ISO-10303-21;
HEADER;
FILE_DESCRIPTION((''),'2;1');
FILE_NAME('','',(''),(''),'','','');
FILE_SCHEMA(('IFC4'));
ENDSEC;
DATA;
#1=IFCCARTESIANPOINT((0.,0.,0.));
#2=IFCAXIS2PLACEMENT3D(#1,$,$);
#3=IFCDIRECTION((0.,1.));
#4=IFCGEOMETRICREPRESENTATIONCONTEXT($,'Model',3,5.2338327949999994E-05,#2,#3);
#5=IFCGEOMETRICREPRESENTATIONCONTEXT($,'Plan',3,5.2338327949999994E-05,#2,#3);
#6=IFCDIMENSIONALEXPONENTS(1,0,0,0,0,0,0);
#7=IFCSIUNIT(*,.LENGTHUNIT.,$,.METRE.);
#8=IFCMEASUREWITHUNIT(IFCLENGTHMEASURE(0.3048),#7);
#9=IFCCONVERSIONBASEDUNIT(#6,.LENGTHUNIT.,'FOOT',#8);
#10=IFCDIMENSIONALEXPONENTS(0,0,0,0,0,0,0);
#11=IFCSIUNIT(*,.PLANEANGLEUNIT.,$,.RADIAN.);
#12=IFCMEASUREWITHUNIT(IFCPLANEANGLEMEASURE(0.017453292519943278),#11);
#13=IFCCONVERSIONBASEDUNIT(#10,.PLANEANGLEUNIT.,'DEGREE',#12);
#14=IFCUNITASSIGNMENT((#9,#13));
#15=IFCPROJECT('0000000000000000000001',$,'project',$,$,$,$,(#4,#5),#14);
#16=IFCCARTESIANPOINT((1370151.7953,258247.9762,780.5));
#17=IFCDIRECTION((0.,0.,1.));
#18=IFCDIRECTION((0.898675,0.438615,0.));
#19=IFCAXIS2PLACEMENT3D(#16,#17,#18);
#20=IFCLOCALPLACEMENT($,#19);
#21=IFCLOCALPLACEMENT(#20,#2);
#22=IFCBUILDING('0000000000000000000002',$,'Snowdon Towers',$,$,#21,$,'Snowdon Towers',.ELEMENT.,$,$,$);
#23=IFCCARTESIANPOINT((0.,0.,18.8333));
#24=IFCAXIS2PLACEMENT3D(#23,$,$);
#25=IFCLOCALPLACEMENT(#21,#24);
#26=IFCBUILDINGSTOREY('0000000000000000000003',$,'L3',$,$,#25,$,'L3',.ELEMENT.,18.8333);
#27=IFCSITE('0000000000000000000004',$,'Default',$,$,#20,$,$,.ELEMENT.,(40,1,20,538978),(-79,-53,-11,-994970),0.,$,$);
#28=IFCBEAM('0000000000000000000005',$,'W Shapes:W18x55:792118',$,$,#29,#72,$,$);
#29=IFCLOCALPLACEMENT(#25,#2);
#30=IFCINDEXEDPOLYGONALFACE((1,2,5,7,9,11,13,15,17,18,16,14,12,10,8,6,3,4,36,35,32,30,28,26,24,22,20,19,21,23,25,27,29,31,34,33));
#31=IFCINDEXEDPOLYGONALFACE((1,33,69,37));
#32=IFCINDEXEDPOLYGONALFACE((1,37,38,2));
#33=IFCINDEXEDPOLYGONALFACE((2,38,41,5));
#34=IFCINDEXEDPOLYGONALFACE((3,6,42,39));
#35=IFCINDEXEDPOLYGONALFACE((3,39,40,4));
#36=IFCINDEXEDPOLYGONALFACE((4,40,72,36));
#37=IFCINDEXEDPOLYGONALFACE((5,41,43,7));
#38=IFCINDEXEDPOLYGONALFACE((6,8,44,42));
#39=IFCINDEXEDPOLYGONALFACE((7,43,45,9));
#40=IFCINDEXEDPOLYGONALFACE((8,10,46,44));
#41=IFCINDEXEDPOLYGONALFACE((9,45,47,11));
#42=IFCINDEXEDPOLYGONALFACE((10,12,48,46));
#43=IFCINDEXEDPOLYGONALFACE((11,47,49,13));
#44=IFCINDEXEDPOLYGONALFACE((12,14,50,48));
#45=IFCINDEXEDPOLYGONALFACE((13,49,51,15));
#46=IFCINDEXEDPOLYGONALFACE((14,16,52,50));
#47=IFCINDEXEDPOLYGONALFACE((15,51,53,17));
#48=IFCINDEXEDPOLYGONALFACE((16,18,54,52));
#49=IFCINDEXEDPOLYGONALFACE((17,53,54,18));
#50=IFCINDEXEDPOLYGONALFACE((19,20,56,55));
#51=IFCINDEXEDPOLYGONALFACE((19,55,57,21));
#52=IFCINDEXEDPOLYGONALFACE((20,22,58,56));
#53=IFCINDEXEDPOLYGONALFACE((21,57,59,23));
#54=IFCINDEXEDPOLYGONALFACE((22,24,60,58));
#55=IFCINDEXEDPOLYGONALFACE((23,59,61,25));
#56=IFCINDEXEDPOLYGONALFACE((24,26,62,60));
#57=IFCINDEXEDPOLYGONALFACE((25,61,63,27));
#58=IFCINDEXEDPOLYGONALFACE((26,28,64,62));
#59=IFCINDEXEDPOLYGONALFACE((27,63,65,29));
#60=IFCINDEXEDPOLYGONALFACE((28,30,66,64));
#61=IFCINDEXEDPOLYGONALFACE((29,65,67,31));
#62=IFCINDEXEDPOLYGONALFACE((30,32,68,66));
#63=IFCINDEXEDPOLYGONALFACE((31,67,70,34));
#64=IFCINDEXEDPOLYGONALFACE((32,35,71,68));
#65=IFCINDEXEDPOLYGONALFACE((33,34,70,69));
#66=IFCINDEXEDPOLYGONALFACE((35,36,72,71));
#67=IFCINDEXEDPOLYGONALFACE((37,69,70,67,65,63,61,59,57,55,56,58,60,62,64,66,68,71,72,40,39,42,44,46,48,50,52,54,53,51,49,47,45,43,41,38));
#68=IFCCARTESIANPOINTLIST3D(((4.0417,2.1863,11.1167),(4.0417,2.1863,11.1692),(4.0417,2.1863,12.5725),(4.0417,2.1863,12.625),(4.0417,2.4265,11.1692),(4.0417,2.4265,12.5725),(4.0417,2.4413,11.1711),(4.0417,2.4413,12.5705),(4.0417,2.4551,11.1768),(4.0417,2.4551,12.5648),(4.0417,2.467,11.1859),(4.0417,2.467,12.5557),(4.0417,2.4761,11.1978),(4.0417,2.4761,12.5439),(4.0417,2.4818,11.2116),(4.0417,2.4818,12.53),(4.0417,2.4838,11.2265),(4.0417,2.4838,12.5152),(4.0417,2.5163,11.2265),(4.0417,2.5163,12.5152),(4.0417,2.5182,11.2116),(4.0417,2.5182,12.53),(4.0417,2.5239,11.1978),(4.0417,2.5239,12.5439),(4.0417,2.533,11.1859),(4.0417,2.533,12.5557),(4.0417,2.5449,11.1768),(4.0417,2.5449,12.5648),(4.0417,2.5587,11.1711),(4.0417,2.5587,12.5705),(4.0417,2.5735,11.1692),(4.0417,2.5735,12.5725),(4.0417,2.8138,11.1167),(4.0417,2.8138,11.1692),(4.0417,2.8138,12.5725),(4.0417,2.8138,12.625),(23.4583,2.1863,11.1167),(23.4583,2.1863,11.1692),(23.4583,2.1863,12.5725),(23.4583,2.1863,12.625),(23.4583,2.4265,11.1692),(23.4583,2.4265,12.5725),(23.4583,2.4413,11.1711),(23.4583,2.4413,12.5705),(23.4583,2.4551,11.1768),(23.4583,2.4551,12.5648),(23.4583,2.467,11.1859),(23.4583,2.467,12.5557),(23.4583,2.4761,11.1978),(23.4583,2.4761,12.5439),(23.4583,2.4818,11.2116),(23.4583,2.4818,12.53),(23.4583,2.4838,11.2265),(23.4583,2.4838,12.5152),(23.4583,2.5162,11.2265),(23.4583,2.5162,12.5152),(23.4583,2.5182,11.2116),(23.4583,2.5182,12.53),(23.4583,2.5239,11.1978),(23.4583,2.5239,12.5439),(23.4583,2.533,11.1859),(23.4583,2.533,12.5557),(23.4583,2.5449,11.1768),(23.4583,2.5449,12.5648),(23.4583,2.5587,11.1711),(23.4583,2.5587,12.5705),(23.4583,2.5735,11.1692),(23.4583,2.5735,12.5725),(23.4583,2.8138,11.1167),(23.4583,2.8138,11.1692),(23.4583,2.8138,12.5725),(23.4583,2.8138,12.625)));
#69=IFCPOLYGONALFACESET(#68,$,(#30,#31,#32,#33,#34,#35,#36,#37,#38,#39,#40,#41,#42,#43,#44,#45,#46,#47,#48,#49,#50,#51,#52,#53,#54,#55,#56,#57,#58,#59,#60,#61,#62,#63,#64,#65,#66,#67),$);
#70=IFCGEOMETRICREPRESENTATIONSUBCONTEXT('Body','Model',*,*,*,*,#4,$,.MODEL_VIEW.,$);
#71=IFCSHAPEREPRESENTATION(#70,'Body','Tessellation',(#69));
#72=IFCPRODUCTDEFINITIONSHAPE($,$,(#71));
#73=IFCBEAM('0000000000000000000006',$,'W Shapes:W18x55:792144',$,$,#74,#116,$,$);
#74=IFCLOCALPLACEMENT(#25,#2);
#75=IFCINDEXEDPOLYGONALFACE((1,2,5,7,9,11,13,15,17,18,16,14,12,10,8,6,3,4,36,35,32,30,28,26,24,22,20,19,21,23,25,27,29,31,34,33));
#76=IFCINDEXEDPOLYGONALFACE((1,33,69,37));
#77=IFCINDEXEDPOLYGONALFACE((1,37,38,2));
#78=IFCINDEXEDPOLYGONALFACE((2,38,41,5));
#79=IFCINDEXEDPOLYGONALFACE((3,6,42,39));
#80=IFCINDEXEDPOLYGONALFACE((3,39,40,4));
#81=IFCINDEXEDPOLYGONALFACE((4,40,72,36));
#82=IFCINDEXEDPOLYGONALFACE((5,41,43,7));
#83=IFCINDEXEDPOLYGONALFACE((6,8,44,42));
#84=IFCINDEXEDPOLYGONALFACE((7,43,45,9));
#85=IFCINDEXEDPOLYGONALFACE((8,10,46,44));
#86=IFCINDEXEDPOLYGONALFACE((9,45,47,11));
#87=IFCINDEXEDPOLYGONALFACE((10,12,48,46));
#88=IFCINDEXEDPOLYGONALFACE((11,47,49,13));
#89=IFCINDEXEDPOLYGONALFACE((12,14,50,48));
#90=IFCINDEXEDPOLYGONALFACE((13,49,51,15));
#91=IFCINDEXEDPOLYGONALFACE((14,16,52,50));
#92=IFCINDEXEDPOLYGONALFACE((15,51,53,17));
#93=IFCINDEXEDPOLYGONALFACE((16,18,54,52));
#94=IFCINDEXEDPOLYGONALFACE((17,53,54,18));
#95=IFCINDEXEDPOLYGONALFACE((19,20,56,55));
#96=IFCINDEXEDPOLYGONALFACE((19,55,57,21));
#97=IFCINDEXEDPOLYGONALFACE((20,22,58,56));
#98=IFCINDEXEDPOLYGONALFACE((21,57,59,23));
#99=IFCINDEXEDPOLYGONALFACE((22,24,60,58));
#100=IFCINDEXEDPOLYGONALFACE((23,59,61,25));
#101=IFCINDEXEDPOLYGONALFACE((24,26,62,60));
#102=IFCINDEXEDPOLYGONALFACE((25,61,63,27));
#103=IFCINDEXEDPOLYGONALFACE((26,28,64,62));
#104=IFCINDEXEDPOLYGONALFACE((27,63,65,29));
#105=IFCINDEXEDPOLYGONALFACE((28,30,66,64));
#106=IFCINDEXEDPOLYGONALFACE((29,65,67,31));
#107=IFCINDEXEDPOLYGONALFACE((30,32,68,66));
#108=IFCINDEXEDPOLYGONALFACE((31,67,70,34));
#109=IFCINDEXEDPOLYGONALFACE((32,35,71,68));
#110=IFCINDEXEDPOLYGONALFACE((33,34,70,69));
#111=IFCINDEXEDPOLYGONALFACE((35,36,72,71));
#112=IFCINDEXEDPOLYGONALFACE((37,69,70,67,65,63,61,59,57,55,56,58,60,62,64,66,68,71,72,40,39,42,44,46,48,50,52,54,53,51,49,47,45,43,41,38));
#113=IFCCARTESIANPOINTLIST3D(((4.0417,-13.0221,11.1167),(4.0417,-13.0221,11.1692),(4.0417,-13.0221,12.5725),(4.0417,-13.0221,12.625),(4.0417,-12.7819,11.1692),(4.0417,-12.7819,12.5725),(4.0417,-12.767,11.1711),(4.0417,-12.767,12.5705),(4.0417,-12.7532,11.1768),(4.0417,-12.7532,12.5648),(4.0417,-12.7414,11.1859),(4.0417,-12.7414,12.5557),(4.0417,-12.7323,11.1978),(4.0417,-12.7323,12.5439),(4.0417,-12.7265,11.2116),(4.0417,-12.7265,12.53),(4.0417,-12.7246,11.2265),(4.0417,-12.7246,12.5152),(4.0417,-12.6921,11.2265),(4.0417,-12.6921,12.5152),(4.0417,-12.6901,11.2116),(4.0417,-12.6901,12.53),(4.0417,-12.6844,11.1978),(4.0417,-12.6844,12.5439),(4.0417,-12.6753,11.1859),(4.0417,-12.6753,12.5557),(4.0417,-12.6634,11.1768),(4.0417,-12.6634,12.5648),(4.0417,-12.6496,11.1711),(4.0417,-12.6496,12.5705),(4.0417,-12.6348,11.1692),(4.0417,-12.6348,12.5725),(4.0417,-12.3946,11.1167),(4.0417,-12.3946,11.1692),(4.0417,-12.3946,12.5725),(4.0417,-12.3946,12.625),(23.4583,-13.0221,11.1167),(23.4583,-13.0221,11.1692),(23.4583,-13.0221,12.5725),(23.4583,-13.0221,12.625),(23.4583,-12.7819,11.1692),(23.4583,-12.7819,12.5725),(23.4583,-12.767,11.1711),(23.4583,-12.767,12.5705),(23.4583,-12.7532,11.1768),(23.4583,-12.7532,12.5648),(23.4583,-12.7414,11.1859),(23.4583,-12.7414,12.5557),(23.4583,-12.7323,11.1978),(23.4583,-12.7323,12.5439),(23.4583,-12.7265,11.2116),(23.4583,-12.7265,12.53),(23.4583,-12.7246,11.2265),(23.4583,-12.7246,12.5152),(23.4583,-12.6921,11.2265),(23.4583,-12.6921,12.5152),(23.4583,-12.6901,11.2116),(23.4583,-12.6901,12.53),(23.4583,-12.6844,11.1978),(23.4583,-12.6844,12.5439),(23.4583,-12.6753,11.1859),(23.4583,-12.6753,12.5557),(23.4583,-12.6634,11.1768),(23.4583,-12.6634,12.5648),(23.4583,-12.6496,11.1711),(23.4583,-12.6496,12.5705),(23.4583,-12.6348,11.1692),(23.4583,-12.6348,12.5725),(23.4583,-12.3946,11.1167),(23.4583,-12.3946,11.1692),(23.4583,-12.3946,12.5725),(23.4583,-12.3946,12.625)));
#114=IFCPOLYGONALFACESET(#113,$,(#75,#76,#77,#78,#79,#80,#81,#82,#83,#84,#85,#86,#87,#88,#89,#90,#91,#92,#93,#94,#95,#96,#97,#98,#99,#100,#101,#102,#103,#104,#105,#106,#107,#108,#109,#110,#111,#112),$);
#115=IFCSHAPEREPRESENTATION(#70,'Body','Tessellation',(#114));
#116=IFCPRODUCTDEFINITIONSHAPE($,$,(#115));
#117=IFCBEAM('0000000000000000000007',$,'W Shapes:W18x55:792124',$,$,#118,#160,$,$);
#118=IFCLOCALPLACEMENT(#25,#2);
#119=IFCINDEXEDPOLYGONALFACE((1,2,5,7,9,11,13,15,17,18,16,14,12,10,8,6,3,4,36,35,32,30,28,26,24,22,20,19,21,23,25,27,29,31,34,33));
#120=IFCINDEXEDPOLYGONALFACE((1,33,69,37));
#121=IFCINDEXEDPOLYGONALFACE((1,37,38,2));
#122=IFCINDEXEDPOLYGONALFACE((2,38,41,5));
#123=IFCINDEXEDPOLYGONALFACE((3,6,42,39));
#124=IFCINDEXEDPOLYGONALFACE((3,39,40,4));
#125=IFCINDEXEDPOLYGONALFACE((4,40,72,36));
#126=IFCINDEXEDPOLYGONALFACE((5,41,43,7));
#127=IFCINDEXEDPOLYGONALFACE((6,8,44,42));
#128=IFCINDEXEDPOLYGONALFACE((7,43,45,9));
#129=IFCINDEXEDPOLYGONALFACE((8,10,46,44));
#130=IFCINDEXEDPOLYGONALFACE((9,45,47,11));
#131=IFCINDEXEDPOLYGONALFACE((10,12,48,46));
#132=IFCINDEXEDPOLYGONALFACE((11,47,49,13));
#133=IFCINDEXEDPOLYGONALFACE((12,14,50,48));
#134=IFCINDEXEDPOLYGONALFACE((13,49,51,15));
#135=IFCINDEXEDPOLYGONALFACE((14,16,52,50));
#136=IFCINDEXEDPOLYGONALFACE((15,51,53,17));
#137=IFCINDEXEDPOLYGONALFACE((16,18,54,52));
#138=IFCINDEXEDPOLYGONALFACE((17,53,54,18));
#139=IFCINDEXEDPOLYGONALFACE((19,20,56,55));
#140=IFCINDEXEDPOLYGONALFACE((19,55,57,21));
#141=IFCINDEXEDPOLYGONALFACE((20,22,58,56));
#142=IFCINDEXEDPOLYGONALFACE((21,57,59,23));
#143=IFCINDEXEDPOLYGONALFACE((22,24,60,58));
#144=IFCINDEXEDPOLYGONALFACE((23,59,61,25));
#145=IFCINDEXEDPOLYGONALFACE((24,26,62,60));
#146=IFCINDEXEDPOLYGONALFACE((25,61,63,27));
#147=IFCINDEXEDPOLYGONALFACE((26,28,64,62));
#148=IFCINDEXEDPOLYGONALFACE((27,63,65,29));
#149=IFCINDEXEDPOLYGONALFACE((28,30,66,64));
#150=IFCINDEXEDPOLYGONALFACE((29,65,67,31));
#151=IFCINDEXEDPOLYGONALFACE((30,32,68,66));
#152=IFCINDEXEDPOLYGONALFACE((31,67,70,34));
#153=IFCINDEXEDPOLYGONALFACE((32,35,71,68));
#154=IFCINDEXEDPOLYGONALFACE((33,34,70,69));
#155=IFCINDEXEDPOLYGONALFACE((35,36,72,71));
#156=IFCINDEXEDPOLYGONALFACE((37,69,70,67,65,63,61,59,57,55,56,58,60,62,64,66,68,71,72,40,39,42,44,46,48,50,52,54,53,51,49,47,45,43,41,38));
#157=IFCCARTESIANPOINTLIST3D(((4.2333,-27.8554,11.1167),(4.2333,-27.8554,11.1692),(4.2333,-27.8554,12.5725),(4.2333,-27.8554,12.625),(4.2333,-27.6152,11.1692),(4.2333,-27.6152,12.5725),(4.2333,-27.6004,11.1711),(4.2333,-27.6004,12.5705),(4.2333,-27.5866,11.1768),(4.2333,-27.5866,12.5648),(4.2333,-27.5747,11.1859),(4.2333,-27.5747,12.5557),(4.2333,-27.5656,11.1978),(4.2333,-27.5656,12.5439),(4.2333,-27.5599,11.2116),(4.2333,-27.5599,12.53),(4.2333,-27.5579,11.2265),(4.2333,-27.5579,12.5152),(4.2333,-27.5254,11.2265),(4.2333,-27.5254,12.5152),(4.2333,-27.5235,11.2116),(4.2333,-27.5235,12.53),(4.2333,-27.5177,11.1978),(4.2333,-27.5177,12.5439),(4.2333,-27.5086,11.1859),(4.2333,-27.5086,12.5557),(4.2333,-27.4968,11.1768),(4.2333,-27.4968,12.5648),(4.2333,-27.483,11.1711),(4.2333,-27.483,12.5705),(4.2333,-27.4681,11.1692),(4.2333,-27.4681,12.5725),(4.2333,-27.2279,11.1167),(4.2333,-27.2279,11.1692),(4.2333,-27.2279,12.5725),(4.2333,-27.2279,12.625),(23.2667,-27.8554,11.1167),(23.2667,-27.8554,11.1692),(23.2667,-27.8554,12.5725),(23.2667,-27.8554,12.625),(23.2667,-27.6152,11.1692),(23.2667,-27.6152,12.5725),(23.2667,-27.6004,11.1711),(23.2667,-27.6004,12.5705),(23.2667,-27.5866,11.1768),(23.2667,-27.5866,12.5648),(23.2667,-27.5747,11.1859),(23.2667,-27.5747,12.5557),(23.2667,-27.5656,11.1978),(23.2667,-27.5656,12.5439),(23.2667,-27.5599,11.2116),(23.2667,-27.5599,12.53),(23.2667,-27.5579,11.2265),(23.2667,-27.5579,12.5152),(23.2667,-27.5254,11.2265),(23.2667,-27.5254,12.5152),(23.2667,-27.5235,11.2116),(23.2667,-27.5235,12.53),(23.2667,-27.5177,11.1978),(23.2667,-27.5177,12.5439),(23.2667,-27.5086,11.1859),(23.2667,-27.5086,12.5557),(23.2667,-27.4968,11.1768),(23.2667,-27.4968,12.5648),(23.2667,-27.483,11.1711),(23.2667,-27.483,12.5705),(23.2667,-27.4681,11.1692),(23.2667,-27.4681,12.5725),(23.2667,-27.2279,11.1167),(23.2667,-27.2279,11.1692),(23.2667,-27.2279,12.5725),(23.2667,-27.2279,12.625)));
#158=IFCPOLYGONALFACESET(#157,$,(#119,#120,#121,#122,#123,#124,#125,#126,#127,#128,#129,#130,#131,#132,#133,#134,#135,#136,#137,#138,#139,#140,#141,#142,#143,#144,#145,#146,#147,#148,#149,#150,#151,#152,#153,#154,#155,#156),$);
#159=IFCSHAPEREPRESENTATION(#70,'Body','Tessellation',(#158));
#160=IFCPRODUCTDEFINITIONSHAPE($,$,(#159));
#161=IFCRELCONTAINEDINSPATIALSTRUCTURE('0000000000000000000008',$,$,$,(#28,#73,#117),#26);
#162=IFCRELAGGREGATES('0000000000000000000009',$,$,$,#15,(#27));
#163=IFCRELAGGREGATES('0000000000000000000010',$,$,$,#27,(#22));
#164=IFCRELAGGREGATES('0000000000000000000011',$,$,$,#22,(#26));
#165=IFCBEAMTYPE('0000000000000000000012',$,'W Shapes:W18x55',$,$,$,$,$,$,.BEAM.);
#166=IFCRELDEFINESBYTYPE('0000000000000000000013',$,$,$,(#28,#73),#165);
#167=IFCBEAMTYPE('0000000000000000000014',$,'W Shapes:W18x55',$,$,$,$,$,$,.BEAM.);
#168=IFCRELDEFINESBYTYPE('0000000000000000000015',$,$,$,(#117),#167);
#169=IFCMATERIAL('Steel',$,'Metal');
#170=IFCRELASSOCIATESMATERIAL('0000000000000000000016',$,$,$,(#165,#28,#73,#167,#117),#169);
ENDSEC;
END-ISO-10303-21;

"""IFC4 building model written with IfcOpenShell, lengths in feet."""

from ifc_helpers import new_model, entity, si_unit, converted_unit, direction, frame, origin, place, context, subcontext, project, spatial, line, arc, indexed_curve, outline, extrude, source, transform, mapped, material, type_object, type_shapes, element, save


model = new_model("IFC4")

# Units and contexts
model_context = context("Model", 3, precision=5.2338327949999994e-05, world=origin(), true_north=direction((0.0, 1.0)))
plan_context = context("Plan", 3, precision=5.2338327949999994e-05, world=origin(), true_north=direction((0.0, 1.0)))
body_context = subcontext(model_context, "Body", "Model", "MODEL_VIEW")
ifc_project = project(units=[converted_unit("LENGTHUNIT", "FOOT", entity("IfcLengthMeasure", 0.3048), si_unit("LENGTHUNIT", "METRE"), dimensions=[1, 0, 0, 0, 0, 0, 0]), converted_unit("PLANEANGLEUNIT", "DEGREE", entity("IfcPlaneAngleMeasure", 0.017453292519943278), si_unit("PLANEANGLEUNIT", "RADIAN"), dimensions=[0, 0, 0, 0, 0, 0, 0])], contexts=[model_context, plan_context])

# Site, building, storey
site_placement = place(None, frame((1370151.7953, 258247.9762, 780.5), z_axis=(0.0, 0.0, 1.0), x_axis=(0.898675, 0.438615, 0.0)))
site = spatial("IfcSite", under=ifc_project, at=site_placement, Name="Default", CompositionType="ELEMENT", RefLatitude=(40, 1, 20, 538978), RefLongitude=(-79, -53, -11, -994970), RefElevation=0.0)
building_placement = place(site_placement, origin())
building = spatial("IfcBuilding", under=site, at=building_placement, Name="Snowdon Towers", LongName="Snowdon Towers", CompositionType="ELEMENT")
storey_placement = place(building_placement, frame((0.0, 0.0, 18.8333)))
storey = spatial("IfcBuildingStorey", under=building, at=storey_placement, Name="L3", LongName="L3", CompositionType="ELEMENT", Elevation=18.8333)

# Beams
ifc_material_1 = material(Name="Steel", Category="Metal")
beam_type_1 = type_object("IfcBeamType", Name="W Shapes:W18x55", PredefinedType="BEAM", material=ifc_material_1)
shared_shape_1 = source(origin(), body_context, "Body", "SweptSolid", [
    extrude(outline(indexed_curve([(-0.7542, -0.3138), (-0.7017, -0.3138), (-0.7017, -0.0735), (-0.6849, -0.033), (-0.6444, -0.0162), (0.6444, -0.0162), (0.6849, -0.033), (0.7017, -0.0735), (0.7017, -0.3138), (0.7542, -0.3138), (0.7542, 0.3138), (0.7017, 0.3138), (0.7017, 0.0735), (0.6849, 0.033), (0.6444, 0.0163), (-0.6444, 0.0163), (-0.6849, 0.033), (-0.7017, 0.0735), (-0.7017, 0.3137), (-0.7542, 0.3137)], segments=[line(1, 2, 3), arc(3, 4, 5), line(5, 6), arc(6, 7, 8), line(8, 9, 10, 11, 12, 13), arc(13, 14, 15), line(15, 16), arc(16, 17, 18), line(18, 19, 20, 1)], self_intersect=False)), frame((-9.7917, 0.0, 0.0), z_axis=(1.0, 0.0, 0.0), x_axis=(0.0, 0.0, -1.0)), (0.0, 0.0, 1.0), 19.4167),
])
type_shapes(beam_type_1, [shared_shape_1])
for number, where, name in (
    (1, (13.8333, 2.5, 11.8708), "W Shapes:W18x55:792118"),
    (2, (13.8333, -12.7083, 11.8708), "W Shapes:W18x55:792144"),
):
    element("IfcBeam", number, at=place(storey_placement, frame(where)), inside=storey, type_object=beam_type_1, material=ifc_material_1, Name=name, context=body_context, shape_type="MappedRepresentation", body=[
        mapped(shared_shape_1, transform((0.0, 0.0, 0.0), scale=1.0)),
    ])
beam_type_2 = type_object("IfcBeamType", Name="W Shapes:W18x55", PredefinedType="BEAM", material=ifc_material_1)
shared_shape_2 = source(origin(), body_context, "Body", "SweptSolid", [
    extrude(outline(indexed_curve([(-0.7542, -0.3138), (-0.7017, -0.3138), (-0.7017, -0.0735), (-0.6849, -0.033), (-0.6444, -0.0162), (0.6444, -0.0162), (0.6849, -0.033), (0.7017, -0.0735), (0.7017, -0.3138), (0.7542, -0.3138), (0.7542, 0.3138), (0.7017, 0.3138), (0.7017, 0.0735), (0.6849, 0.033), (0.6444, 0.0163), (-0.6444, 0.0163), (-0.6849, 0.033), (-0.7017, 0.0735), (-0.7017, 0.3137), (-0.7542, 0.3137)], segments=[line(1, 2, 3), arc(3, 4, 5), line(5, 6), arc(6, 7, 8), line(8, 9, 10, 11, 12, 13), arc(13, 14, 15), line(15, 16), arc(16, 17, 18), line(18, 19, 20, 1)], self_intersect=False)), frame((-9.6, 0.0, 0.0), z_axis=(1.0, 0.0, 0.0), x_axis=(0.0, 0.0, -1.0)), (0.0, 0.0, 1.0), 19.0333),
])
type_shapes(beam_type_2, [shared_shape_2])
beam_1_placement = place(storey_placement, frame((13.8333, -27.5417, 11.8708)))
element("IfcBeam", 3, at=beam_1_placement, inside=storey, type_object=beam_type_2, material=ifc_material_1, Name="W Shapes:W18x55:792124", context=body_context, shape_type="MappedRepresentation", body=[
    mapped(shared_shape_2, transform((0.0, 0.0, 0.0), scale=1.0)),
])

save(model, "model.ifc")
